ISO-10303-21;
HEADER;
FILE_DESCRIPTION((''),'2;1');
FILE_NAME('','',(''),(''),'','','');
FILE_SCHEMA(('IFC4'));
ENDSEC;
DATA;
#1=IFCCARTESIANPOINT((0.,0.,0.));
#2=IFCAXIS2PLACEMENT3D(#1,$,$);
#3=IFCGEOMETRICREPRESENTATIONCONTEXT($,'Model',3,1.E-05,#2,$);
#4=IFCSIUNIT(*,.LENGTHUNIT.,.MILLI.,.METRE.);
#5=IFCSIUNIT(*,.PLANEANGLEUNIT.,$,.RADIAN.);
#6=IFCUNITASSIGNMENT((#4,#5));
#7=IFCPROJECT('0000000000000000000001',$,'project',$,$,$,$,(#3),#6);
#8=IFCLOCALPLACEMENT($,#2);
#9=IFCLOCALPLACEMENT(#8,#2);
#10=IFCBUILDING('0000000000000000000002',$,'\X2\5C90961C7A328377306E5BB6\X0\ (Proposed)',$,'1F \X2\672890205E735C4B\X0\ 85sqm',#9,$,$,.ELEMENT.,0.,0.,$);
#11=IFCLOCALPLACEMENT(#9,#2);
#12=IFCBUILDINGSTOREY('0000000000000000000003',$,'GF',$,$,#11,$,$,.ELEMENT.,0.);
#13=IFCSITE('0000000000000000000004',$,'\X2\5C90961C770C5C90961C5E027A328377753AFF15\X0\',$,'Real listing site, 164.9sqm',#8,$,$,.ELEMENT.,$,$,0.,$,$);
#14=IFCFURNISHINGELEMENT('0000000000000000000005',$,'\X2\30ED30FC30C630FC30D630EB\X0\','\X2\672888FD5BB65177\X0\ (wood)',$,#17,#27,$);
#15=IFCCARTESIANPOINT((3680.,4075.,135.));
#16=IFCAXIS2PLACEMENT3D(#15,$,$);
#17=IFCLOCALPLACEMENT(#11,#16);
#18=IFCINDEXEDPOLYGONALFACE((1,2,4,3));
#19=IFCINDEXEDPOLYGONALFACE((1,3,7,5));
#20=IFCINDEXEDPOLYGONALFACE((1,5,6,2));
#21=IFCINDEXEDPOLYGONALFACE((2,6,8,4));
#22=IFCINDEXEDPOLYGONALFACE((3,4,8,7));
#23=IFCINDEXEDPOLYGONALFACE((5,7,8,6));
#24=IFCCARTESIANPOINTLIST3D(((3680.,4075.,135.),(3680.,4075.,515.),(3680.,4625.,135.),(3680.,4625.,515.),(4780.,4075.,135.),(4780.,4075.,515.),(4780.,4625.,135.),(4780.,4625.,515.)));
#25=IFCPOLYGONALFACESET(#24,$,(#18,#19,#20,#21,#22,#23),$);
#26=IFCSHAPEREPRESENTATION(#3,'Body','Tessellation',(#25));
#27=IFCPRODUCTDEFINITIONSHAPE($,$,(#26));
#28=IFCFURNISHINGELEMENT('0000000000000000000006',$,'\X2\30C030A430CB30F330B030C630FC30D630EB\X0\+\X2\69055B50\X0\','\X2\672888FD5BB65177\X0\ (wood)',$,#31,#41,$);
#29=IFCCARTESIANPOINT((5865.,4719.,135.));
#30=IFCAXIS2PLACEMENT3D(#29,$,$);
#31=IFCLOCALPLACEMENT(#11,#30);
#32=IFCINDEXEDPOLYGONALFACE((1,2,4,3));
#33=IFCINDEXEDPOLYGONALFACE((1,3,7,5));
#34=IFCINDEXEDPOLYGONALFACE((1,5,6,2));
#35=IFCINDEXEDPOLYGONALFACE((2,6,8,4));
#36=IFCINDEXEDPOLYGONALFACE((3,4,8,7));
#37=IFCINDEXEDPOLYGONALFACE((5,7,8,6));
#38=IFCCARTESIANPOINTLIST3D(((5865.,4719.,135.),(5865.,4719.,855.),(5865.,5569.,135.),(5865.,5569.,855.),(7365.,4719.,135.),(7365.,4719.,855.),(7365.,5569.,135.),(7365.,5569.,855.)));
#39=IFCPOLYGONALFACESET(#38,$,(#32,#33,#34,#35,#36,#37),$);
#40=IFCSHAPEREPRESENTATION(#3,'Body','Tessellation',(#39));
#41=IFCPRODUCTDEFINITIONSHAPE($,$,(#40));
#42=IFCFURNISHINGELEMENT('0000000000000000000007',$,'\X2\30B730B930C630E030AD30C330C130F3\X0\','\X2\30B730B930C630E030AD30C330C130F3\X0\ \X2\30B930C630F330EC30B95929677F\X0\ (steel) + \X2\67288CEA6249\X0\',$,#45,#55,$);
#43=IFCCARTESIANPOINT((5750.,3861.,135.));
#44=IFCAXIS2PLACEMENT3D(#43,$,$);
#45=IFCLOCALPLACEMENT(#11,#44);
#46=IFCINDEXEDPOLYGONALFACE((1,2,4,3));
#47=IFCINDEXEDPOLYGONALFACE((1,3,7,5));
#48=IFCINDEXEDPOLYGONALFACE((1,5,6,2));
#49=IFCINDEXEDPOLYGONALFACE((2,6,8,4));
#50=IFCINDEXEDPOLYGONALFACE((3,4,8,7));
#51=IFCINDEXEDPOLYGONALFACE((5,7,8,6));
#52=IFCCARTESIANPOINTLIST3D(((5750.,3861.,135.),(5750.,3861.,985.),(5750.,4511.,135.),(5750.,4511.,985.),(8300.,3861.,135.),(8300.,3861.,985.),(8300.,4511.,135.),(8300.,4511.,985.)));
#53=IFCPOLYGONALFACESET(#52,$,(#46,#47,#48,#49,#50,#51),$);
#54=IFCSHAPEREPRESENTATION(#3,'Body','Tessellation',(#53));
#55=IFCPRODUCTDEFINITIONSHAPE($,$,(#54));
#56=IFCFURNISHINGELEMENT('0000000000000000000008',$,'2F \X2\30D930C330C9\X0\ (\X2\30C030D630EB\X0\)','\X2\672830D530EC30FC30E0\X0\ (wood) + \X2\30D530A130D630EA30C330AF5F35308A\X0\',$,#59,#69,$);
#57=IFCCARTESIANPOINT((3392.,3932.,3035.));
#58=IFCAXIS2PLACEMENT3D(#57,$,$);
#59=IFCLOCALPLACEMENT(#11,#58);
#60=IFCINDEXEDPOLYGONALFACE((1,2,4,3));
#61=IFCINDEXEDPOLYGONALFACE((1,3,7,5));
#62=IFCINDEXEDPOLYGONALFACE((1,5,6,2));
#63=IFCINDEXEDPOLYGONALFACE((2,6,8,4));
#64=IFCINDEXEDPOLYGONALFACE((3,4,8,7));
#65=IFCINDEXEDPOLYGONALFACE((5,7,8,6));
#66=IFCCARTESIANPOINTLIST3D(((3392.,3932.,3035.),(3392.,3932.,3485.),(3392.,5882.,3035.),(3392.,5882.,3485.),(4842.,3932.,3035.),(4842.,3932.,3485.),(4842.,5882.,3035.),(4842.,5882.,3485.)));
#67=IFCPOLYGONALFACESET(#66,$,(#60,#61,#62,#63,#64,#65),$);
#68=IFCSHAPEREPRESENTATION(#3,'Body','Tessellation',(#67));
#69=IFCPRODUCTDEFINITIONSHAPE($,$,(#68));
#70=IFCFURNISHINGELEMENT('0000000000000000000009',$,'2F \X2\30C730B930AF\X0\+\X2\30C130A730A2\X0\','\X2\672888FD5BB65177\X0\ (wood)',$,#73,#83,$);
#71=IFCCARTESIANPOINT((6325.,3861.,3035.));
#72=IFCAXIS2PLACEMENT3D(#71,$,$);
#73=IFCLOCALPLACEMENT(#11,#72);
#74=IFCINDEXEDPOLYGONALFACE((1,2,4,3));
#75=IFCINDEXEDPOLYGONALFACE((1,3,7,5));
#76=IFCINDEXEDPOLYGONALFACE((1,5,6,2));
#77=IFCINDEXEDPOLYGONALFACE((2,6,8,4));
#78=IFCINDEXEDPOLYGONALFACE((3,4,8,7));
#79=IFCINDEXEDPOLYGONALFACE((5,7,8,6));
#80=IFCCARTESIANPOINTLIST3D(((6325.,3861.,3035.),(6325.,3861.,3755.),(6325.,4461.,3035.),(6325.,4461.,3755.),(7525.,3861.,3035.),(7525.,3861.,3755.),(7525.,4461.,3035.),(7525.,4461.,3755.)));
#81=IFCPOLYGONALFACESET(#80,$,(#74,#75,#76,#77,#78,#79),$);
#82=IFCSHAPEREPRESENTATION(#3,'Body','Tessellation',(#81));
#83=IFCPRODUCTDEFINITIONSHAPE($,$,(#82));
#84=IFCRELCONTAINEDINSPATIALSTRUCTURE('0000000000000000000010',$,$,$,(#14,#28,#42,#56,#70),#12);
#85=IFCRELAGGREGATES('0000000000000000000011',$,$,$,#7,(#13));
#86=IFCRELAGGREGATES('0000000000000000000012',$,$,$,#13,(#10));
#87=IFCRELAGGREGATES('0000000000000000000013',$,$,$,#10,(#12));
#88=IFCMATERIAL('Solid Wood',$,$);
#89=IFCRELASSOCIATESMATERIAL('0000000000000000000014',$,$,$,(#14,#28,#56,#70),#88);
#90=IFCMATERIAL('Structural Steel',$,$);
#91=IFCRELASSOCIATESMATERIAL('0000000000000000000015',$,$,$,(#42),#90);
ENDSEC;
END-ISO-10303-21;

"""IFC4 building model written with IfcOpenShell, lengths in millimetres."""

from ifc_helpers import new_model, si_unit, frame, frame_2d, origin, place, context, project, spatial, rectangle, extrude, material, element, save


model = new_model("IFC4")

# Units and contexts
model_context = context("Model", 3, precision=1e-05, world=origin())
ifc_project = project(units=[si_unit("LENGTHUNIT", "METRE", prefix="MILLI"), si_unit("PLANEANGLEUNIT", "RADIAN")], contexts=[model_context])

# Site, building, storey
site_placement = place(None, origin())
site = spatial("IfcSite", under=ifc_project, at=site_placement, Name="岐阜県岐阜市稲荷町５", ObjectType="Real listing site, 164.9sqm", CompositionType="ELEMENT", RefElevation=0.0)
building_placement = place(site_placement, origin())
building = spatial("IfcBuilding", under=site, at=building_placement, Name="岐阜稲荷の家 (Proposed)", ObjectType="1F 木造平屋 85sqm", CompositionType="ELEMENT", ElevationOfRefHeight=0.0, ElevationOfTerrain=0.0)
storey_placement = place(building_placement, origin())
storey = spatial("IfcBuildingStorey", under=building, at=storey_placement, Name="GF", CompositionType="ELEMENT", Elevation=0.0)

# Shared definitions
ifc_material_1 = material(Name="Solid Wood")

# Shared definitions
ifc_material_2 = material(Name="Structural Steel")

# Furnishing elements
furnishing_1_placement = place(storey_placement, frame((3680.0, 4075.0, 135.0)))
element("IfcFurnishingElement", 1, at=furnishing_1_placement, inside=storey, material=ifc_material_1, Name="ローテーブル", Description="木製家具 (wood)", context=model_context, shape_type="SweptSolid", body=[
    extrude(rectangle(XDim=1100.0, YDim=550.0, at=frame_2d((550.0, 275.0))), frame((3680.0, 4075.0, 135.0)), (0.0, 0.0, 1.0), 380.0),
])
furnishing_2_placement = place(storey_placement, frame((5865.0, 4719.0, 135.0)))
element("IfcFurnishingElement", 2, at=furnishing_2_placement, inside=storey, material=ifc_material_1, Name="ダイニングテーブル+椅子", Description="木製家具 (wood)", context=model_context, shape_type="SweptSolid", body=[
    extrude(rectangle(XDim=1500.0, YDim=850.0, at=frame_2d((750.0, 425.0))), frame((5865.0, 4719.0, 135.0)), (0.0, 0.0, 1.0), 720.0),
])
furnishing_3_placement = place(storey_placement, frame((5750.0, 3861.0, 135.0)))
element("IfcFurnishingElement", 3, at=furnishing_3_placement, inside=storey, material=ifc_material_2, Name="システムキッチン", Description="システムキッチン ステンレス天板 (steel) + 木質扉", context=model_context, shape_type="SweptSolid", body=[
    extrude(rectangle(XDim=2550.0, YDim=650.0, at=frame_2d((1275.0, 325.0))), frame((5750.0, 3861.0, 135.0)), (0.0, 0.0, 1.0), 850.0),
])
furnishing_4_placement = place(storey_placement, frame((3392.0, 3932.0, 3035.0)))
element("IfcFurnishingElement", 4, at=furnishing_4_placement, inside=storey, material=ifc_material_1, Name="2F ベッド (ダブル)", Description="木フレーム (wood) + ファブリック張り", context=model_context, shape_type="SweptSolid", body=[
    extrude(rectangle(XDim=1450.0, YDim=1950.0, at=frame_2d((725.0, 975.0))), frame((3392.0, 3932.0, 3035.0)), (0.0, 0.0, 1.0), 450.0),
])
furnishing_5_placement = place(storey_placement, frame((6325.0, 3861.0, 3035.0)))
element("IfcFurnishingElement", 5, at=furnishing_5_placement, inside=storey, material=ifc_material_1, Name="2F デスク+チェア", Description="木製家具 (wood)", context=model_context, shape_type="SweptSolid", body=[
    extrude(rectangle(XDim=1200.0, YDim=600.0, at=frame_2d((600.0, 300.0))), frame((6325.0, 3861.0, 3035.0)), (0.0, 0.0, 1.0), 720.0),
])

save(model, "model.ifc")
